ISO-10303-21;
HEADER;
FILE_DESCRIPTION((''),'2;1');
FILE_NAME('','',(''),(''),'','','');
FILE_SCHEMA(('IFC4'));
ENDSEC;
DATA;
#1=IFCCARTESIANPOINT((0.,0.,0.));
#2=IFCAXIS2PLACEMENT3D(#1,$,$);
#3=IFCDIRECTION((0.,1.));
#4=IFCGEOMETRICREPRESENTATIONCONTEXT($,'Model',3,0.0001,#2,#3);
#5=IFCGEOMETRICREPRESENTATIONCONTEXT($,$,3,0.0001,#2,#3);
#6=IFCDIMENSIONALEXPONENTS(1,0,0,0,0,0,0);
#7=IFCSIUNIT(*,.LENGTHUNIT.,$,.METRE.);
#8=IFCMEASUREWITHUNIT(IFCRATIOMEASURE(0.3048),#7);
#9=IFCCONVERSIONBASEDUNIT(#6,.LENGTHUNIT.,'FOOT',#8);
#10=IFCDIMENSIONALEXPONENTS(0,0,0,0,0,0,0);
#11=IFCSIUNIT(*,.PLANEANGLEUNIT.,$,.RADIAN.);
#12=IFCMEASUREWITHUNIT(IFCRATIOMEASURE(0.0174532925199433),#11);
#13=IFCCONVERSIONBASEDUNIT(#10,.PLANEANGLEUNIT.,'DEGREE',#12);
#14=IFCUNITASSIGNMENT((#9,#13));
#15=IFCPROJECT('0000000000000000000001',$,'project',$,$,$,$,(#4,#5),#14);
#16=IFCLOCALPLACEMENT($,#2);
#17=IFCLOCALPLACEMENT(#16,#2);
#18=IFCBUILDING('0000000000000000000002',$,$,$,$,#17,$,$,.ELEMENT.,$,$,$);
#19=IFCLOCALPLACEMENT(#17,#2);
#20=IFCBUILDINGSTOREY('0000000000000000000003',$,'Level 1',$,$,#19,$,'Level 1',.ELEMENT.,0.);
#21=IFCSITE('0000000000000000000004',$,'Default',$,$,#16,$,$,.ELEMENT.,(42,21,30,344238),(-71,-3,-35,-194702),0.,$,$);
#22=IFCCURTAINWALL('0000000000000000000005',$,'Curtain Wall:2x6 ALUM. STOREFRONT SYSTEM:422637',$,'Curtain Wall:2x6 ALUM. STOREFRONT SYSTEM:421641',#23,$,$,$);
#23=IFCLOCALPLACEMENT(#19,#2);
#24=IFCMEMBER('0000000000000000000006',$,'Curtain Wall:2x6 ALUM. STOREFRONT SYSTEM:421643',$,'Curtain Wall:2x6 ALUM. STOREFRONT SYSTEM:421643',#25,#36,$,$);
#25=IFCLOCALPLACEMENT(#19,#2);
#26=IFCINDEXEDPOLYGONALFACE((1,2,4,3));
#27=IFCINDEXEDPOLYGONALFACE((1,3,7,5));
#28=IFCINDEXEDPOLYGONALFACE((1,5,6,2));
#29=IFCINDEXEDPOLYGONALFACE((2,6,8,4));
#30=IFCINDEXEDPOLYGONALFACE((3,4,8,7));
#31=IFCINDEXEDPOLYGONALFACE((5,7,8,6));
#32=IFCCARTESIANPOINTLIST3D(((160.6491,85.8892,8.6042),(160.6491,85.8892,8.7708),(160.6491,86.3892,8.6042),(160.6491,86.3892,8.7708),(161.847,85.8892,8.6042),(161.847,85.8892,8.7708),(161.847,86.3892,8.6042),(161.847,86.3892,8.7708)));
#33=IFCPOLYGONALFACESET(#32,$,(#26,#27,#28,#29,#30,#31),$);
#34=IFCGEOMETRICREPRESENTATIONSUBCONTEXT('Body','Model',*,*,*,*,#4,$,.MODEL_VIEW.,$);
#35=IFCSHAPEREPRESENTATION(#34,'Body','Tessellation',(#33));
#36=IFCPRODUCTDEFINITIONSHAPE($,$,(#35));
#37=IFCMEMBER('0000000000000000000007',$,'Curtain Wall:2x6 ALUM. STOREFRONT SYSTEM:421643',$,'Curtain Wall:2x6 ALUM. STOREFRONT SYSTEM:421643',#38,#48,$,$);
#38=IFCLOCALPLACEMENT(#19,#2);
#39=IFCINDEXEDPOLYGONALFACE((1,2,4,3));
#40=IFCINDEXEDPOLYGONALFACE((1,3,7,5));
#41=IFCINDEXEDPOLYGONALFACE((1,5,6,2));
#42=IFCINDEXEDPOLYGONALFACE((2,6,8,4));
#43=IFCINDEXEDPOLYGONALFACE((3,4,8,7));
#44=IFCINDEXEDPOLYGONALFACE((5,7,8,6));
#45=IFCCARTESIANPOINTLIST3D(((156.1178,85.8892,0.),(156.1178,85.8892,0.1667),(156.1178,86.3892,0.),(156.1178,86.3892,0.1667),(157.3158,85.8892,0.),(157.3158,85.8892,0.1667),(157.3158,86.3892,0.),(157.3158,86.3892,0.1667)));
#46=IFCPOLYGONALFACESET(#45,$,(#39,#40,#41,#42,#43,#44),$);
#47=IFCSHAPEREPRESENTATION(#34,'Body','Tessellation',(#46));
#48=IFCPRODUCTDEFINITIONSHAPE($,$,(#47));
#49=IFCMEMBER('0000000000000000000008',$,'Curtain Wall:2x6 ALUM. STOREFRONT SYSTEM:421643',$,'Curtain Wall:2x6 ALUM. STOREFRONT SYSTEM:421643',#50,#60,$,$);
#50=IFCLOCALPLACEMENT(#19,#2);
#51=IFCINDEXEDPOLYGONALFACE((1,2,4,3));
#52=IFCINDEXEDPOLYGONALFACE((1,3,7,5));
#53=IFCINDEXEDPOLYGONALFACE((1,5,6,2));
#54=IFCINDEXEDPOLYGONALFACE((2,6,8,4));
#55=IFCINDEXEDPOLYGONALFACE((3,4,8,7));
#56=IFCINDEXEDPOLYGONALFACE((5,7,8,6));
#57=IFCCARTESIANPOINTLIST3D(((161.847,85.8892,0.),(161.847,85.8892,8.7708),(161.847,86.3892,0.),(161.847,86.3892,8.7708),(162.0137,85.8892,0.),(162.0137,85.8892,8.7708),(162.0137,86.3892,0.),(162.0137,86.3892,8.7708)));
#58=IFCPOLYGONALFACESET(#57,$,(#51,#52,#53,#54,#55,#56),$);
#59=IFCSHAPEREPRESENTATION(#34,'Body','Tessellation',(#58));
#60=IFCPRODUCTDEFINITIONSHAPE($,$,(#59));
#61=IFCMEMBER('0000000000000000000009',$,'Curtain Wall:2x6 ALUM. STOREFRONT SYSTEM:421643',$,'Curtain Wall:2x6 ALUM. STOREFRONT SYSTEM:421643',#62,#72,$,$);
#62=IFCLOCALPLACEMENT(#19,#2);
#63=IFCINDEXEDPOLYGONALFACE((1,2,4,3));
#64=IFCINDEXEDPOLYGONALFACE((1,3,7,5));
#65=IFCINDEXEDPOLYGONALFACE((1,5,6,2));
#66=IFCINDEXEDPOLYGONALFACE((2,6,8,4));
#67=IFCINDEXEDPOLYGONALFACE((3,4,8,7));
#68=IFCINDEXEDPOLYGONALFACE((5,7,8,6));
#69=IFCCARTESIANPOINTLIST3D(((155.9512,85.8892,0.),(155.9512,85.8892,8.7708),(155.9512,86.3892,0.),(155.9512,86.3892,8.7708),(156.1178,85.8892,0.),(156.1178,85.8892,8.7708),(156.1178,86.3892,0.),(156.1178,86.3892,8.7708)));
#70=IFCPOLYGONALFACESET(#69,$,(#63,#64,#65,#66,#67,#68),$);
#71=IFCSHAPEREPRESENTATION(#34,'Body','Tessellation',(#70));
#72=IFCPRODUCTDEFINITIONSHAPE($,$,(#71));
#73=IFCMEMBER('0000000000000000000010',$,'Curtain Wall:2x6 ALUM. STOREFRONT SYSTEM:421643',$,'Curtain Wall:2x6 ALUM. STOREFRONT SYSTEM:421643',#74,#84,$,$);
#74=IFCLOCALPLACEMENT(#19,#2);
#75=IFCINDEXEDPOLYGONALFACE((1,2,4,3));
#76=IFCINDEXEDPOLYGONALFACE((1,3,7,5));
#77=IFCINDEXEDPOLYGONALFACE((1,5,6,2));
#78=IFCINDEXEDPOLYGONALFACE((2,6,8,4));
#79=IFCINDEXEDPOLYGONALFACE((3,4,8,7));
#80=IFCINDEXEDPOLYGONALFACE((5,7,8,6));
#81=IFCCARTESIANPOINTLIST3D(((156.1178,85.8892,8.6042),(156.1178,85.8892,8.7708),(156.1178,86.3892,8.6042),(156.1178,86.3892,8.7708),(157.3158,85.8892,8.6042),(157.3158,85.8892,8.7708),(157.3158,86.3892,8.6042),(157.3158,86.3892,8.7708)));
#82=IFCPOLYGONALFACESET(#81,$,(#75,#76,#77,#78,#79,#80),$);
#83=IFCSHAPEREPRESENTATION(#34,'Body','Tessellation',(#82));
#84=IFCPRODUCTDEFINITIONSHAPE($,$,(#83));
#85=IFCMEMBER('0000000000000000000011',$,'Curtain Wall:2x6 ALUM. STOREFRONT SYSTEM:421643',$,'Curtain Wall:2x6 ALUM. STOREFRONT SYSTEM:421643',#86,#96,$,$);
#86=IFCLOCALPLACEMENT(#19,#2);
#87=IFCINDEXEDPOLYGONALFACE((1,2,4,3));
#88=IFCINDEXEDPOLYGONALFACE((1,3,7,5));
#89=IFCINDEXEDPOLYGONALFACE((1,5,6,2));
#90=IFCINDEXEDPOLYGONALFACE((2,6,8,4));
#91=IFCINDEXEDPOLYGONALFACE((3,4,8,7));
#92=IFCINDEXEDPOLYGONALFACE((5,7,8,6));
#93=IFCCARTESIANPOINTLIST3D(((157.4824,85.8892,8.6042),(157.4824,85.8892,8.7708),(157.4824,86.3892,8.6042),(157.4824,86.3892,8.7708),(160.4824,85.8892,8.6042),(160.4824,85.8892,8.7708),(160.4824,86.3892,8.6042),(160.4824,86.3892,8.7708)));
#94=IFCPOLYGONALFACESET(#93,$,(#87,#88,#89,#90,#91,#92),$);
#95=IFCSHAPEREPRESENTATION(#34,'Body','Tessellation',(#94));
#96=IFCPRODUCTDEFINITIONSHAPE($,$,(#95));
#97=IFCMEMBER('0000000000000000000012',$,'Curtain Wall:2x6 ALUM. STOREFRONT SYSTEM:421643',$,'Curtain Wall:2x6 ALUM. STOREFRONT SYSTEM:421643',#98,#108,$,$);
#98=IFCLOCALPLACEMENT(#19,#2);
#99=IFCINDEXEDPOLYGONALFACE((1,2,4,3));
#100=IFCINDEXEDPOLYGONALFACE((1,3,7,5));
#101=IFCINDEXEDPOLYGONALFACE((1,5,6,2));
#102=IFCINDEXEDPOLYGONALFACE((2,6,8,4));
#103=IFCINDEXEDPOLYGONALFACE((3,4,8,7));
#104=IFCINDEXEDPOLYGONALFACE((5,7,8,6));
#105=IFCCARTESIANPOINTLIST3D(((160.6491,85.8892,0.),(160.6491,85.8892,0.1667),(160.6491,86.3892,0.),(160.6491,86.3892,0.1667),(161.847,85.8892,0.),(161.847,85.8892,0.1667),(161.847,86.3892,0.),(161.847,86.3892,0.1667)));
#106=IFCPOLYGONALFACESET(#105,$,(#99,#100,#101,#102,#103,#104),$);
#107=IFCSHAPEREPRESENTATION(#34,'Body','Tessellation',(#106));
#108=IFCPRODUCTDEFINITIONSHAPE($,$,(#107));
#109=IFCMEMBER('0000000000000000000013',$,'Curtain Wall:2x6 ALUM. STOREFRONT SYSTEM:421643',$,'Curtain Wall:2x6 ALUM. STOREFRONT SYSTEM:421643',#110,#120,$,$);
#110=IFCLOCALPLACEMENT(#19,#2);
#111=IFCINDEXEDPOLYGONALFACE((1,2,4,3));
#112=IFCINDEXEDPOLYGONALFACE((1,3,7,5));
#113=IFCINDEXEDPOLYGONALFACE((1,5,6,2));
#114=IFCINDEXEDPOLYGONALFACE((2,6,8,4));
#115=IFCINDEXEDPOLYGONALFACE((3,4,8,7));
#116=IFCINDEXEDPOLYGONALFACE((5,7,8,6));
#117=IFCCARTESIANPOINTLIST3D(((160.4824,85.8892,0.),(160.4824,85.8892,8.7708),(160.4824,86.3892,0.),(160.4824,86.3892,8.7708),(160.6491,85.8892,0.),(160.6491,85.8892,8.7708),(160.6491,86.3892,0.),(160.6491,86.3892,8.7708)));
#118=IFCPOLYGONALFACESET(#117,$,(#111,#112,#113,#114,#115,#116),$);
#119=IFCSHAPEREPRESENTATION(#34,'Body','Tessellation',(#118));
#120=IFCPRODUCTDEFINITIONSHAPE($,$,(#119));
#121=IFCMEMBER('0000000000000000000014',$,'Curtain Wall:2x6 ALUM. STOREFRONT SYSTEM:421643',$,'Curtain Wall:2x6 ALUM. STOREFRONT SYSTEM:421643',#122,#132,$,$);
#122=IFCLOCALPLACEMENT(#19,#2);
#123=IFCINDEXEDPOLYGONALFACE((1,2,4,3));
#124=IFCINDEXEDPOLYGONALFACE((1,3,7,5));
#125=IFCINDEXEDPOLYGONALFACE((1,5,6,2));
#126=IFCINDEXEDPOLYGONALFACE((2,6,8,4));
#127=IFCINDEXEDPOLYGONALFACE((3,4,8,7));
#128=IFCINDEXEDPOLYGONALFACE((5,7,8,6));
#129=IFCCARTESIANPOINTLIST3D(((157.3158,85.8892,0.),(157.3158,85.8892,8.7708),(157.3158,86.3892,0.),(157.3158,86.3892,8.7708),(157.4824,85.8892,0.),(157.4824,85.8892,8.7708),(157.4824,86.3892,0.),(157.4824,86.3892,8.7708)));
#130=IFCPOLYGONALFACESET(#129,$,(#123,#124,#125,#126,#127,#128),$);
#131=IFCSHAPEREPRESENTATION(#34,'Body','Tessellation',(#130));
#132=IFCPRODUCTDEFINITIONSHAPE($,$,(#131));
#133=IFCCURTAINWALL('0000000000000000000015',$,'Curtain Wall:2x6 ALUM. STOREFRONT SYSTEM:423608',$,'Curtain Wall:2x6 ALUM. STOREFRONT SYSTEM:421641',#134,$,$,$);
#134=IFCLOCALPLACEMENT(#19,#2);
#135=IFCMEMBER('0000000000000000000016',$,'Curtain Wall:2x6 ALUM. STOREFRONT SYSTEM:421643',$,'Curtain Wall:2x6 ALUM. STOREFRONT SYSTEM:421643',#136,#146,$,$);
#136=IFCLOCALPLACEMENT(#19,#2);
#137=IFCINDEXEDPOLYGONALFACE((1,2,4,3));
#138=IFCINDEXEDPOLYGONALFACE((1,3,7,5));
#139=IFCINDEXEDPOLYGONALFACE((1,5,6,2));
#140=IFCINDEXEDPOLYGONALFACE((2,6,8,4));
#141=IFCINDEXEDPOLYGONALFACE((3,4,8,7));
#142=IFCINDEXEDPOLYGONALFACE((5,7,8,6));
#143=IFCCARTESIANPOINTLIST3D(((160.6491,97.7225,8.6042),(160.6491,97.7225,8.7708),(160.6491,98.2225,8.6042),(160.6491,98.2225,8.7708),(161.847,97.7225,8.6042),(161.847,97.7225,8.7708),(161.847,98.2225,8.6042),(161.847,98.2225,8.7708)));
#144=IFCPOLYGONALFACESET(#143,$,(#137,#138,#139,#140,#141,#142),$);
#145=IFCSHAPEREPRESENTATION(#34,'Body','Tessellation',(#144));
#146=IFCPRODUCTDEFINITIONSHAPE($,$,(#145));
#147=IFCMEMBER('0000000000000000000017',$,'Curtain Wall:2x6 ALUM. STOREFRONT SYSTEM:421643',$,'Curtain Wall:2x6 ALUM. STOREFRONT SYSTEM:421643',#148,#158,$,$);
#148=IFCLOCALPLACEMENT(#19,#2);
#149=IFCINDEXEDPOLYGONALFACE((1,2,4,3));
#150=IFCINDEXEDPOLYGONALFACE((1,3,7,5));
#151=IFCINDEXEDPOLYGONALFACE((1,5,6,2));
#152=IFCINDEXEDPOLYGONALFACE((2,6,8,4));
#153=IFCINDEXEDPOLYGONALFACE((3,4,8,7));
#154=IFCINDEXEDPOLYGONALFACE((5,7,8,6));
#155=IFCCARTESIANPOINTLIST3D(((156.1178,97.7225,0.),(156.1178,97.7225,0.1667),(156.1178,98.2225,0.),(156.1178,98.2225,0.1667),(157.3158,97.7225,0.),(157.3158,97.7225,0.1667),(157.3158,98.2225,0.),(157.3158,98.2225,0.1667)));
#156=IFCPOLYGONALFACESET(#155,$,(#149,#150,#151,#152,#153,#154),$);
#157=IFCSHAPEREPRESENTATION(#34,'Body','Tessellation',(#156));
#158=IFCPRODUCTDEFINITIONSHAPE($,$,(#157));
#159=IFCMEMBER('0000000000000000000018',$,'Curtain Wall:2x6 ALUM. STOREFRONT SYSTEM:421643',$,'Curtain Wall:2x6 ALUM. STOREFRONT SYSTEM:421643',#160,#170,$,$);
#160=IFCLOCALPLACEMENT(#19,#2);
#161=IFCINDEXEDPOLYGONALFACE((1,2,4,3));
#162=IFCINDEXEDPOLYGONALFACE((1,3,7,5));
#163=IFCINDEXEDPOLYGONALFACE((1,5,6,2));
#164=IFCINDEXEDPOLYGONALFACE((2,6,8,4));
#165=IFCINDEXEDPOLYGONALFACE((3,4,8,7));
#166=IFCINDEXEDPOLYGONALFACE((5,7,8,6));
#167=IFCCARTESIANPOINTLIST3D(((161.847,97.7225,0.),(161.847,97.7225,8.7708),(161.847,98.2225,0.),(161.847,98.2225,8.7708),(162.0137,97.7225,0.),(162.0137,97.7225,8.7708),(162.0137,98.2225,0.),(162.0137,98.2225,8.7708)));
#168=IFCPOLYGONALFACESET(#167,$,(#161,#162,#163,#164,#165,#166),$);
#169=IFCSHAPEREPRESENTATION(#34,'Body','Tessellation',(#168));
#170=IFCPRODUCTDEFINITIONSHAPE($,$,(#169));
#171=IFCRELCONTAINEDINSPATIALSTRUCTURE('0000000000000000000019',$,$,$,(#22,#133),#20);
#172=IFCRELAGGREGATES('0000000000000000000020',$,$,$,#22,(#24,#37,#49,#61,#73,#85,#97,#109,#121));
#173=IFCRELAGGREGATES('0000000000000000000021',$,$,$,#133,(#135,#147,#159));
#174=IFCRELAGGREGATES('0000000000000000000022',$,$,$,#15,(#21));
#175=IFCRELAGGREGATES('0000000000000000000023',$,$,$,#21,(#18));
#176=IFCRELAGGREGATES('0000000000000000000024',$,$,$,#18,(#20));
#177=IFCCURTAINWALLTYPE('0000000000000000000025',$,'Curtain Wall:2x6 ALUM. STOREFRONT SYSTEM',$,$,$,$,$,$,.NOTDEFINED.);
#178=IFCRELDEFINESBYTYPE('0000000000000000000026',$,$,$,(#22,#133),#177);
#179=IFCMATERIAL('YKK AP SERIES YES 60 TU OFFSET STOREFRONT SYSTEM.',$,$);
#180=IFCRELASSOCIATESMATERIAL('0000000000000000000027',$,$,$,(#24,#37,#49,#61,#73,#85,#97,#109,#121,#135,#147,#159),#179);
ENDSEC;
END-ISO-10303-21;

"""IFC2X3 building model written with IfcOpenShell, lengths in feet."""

from ifc_helpers import new_model, entity, si_unit, converted_unit, direction, frame, frame_2d, origin, origin_2d_with_axis, place, context, subcontext, project, spatial, rectangle, extrude, material, type_object, element, aggregate, save


model = new_model("IFC2X3")

# Units and contexts
model_context = context("Model", 3, precision=0.0001, world=origin(), true_north=direction((0.0, 1.0)))
context_of_model = context(None, 3, precision=0.0001, world=origin(), true_north=direction((0.0, 1.0)))
body_context = subcontext(model_context, "Body", "Model", "MODEL_VIEW")
ifc_project = project(units=[converted_unit("LENGTHUNIT", "FOOT", entity("IfcRatioMeasure", 0.3048), si_unit("LENGTHUNIT", "METRE"), dimensions=[1, 0, 0, 0, 0, 0, 0]), converted_unit("PLANEANGLEUNIT", "DEGREE", entity("IfcRatioMeasure", 0.0174532925199433), si_unit("PLANEANGLEUNIT", "RADIAN"), dimensions=[0, 0, 0, 0, 0, 0, 0])], contexts=[model_context, context_of_model])

# Site, building, storey
site_placement = place(None, origin())
site = spatial("IfcSite", under=ifc_project, at=site_placement, Name="Default", CompositionType="ELEMENT", RefLatitude=(42, 21, 30, 344238), RefLongitude=(-71, -3, -35, -194702), RefElevation=0.0)
building_placement = place(site_placement, origin())
building = spatial("IfcBuilding", under=site, at=building_placement, CompositionType="ELEMENT")
storey_placement = place(building_placement, origin())
storey = spatial("IfcBuildingStorey", under=building, at=storey_placement, Name="Level 1", LongName="Level 1", CompositionType="ELEMENT", Elevation=0.0)

# Curtain walls, members
curtain_wall_type = type_object("IfcCurtainWallType", Name="Curtain Wall:2x6 ALUM. STOREFRONT SYSTEM", PredefinedType="NOTDEFINED")
curtain_wall_1_placement = place(storey_placement, origin())
curtain_wall_1 = element("IfcCurtainWall", 1, at=curtain_wall_1_placement, inside=storey, type_object=curtain_wall_type, Name="Curtain Wall:2x6 ALUM. STOREFRONT SYSTEM:422637", ObjectType="Curtain Wall:2x6 ALUM. STOREFRONT SYSTEM:421641")
ifc_material_1 = material(Name="YKK AP SERIES YES 60 TU OFFSET STOREFRONT SYSTEM.")
member_1_placement = place(curtain_wall_1_placement, origin())
member_1 = element("IfcMember", 2, at=member_1_placement, material=ifc_material_1, Name="Curtain Wall:2x6 ALUM. STOREFRONT SYSTEM:421643", ObjectType="Curtain Wall:2x6 ALUM. STOREFRONT SYSTEM:421643", context=body_context, shape_type="SweptSolid", body=[
    extrude(rectangle(XDim=0.1667, YDim=0.5, at=frame_2d((0.0, 0.0), x_axis=(1.0, 0.0))), frame((161.847, 86.1392, 8.6875), z_axis=(-1.0, 0.0, 0.0), x_axis=(0.0, 0.0, -1.0)), (0.0, 0.0, 1.0), 1.1979),
])
member_2_placement = place(curtain_wall_1_placement, origin())
member_2 = element("IfcMember", 3, at=member_2_placement, material=ifc_material_1, Name="Curtain Wall:2x6 ALUM. STOREFRONT SYSTEM:421643", ObjectType="Curtain Wall:2x6 ALUM. STOREFRONT SYSTEM:421643", context=body_context, shape_type="SweptSolid", body=[
    extrude(rectangle(XDim=0.1667, YDim=0.5, at=origin_2d_with_axis()), frame((156.1178, 86.1392, 0.0833), z_axis=(1.0, 0.0, 0.0), x_axis=(0.0, 0.0, -1.0)), (0.0, 0.0, 1.0), 1.1979),
])
member_3_placement = place(curtain_wall_1_placement, origin())
member_3 = element("IfcMember", 4, at=member_3_placement, material=ifc_material_1, Name="Curtain Wall:2x6 ALUM. STOREFRONT SYSTEM:421643", ObjectType="Curtain Wall:2x6 ALUM. STOREFRONT SYSTEM:421643", context=body_context, shape_type="SweptSolid", body=[
    extrude(rectangle(XDim=0.1667, YDim=0.5, at=frame_2d((0.0, 0.0), x_axis=(1.0, 0.0))), frame((161.9303, 86.1392, 0.0), z_axis=(0.0, 0.0, 1.0), x_axis=(-1.0, 0.0, 0.0)), (0.0, 0.0, 1.0), 8.7708),
])
member_4_placement = place(curtain_wall_1_placement, origin())
member_4 = element("IfcMember", 5, at=member_4_placement, material=ifc_material_1, Name="Curtain Wall:2x6 ALUM. STOREFRONT SYSTEM:421643", ObjectType="Curtain Wall:2x6 ALUM. STOREFRONT SYSTEM:421643", context=body_context, shape_type="SweptSolid", body=[
    extrude(rectangle(XDim=0.1667, YDim=0.5, at=frame_2d((0.0, 0.0), x_axis=(1.0, 0.0))), frame((156.0345, 86.1392, 8.7708), z_axis=(0.0, 0.0, -1.0), x_axis=(-1.0, 0.0, 0.0)), (0.0, 0.0, 1.0), 8.7708),
])
member_5_placement = place(curtain_wall_1_placement, origin())
member_5 = element("IfcMember", 6, at=member_5_placement, material=ifc_material_1, Name="Curtain Wall:2x6 ALUM. STOREFRONT SYSTEM:421643", ObjectType="Curtain Wall:2x6 ALUM. STOREFRONT SYSTEM:421643", context=body_context, shape_type="SweptSolid", body=[
    extrude(rectangle(XDim=0.1667, YDim=0.5, at=frame_2d((0.0, 0.0), x_axis=(1.0, 0.0))), frame((157.3158, 86.1392, 8.6875), z_axis=(-1.0, 0.0, 0.0), x_axis=(0.0, 0.0, -1.0)), (0.0, 0.0, 1.0), 1.1979),
])
member_6_placement = place(curtain_wall_1_placement, origin())
member_6 = element("IfcMember", 7, at=member_6_placement, material=ifc_material_1, Name="Curtain Wall:2x6 ALUM. STOREFRONT SYSTEM:421643", ObjectType="Curtain Wall:2x6 ALUM. STOREFRONT SYSTEM:421643", context=body_context, shape_type="SweptSolid", body=[
    extrude(rectangle(XDim=0.1667, YDim=0.5, at=frame_2d((0.0, 0.0), x_axis=(1.0, 0.0))), frame((160.4824, 86.1392, 8.6875), z_axis=(-1.0, 0.0, 0.0), x_axis=(0.0, 0.0, -1.0)), (0.0, 0.0, 1.0), 3.0),
])
member_7_placement = place(curtain_wall_1_placement, origin())
member_7 = element("IfcMember", 8, at=member_7_placement, material=ifc_material_1, Name="Curtain Wall:2x6 ALUM. STOREFRONT SYSTEM:421643", ObjectType="Curtain Wall:2x6 ALUM. STOREFRONT SYSTEM:421643", context=body_context, shape_type="SweptSolid", body=[
    extrude(rectangle(XDim=0.1667, YDim=0.5, at=origin_2d_with_axis()), frame((160.6491, 86.1392, 0.0833), z_axis=(1.0, 0.0, 0.0), x_axis=(0.0, 0.0, -1.0)), (0.0, 0.0, 1.0), 1.1979),
])
member_8_placement = place(curtain_wall_1_placement, origin())
member_8 = element("IfcMember", 9, at=member_8_placement, material=ifc_material_1, Name="Curtain Wall:2x6 ALUM. STOREFRONT SYSTEM:421643", ObjectType="Curtain Wall:2x6 ALUM. STOREFRONT SYSTEM:421643", context=body_context, shape_type="SweptSolid", body=[
    extrude(rectangle(XDim=0.1667, YDim=0.5, at=origin_2d_with_axis()), frame((160.5658, 86.1392, 0.0), z_axis=(0.0, 0.0, 1.0), x_axis=(-1.0, 0.0, 0.0)), (0.0, 0.0, 1.0), 8.7708),
])
member_9_placement = place(curtain_wall_1_placement, origin())
member_9 = element("IfcMember", 10, at=member_9_placement, material=ifc_material_1, Name="Curtain Wall:2x6 ALUM. STOREFRONT SYSTEM:421643", ObjectType="Curtain Wall:2x6 ALUM. STOREFRONT SYSTEM:421643", context=body_context, shape_type="SweptSolid", body=[
    extrude(rectangle(XDim=0.1667, YDim=0.5, at=frame_2d((0.0, 0.0), x_axis=(1.0, 0.0))), frame((157.3991, 86.1392, 0.0), z_axis=(0.0, 0.0, 1.0), x_axis=(-1.0, 0.0, 0.0)), (0.0, 0.0, 1.0), 8.7708),
])
aggregate(curtain_wall_1, [member_1, member_2, member_3, member_4, member_5, member_6, member_7, member_8, member_9])
curtain_wall_2_placement = place(storey_placement, origin())
curtain_wall_2 = element("IfcCurtainWall", 11, at=curtain_wall_2_placement, inside=storey, type_object=curtain_wall_type, Name="Curtain Wall:2x6 ALUM. STOREFRONT SYSTEM:423608", ObjectType="Curtain Wall:2x6 ALUM. STOREFRONT SYSTEM:421641")
member_10_placement = place(curtain_wall_2_placement, origin())
member_10 = element("IfcMember", 12, at=member_10_placement, material=ifc_material_1, Name="Curtain Wall:2x6 ALUM. STOREFRONT SYSTEM:421643", ObjectType="Curtain Wall:2x6 ALUM. STOREFRONT SYSTEM:421643", context=body_context, shape_type="SweptSolid", body=[
    extrude(rectangle(XDim=0.1667, YDim=0.5, at=frame_2d((0.0, 0.0), x_axis=(1.0, 0.0))), frame((161.847, 97.9725, 8.6875), z_axis=(-1.0, 0.0, 0.0), x_axis=(0.0, 0.0, -1.0)), (0.0, 0.0, 1.0), 1.1979),
])
member_11_placement = place(curtain_wall_2_placement, origin())
member_11 = element("IfcMember", 13, at=member_11_placement, material=ifc_material_1, Name="Curtain Wall:2x6 ALUM. STOREFRONT SYSTEM:421643", ObjectType="Curtain Wall:2x6 ALUM. STOREFRONT SYSTEM:421643", context=body_context, shape_type="SweptSolid", body=[
    extrude(rectangle(XDim=0.1667, YDim=0.5, at=origin_2d_with_axis()), frame((156.1178, 97.9725, 0.0833), z_axis=(1.0, 0.0, 0.0), x_axis=(0.0, 0.0, -1.0)), (0.0, 0.0, 1.0), 1.1979),
])
member_12_placement = place(curtain_wall_2_placement, origin())
member_12 = element("IfcMember", 14, at=member_12_placement, material=ifc_material_1, Name="Curtain Wall:2x6 ALUM. STOREFRONT SYSTEM:421643", ObjectType="Curtain Wall:2x6 ALUM. STOREFRONT SYSTEM:421643", context=body_context, shape_type="SweptSolid", body=[
    extrude(rectangle(XDim=0.1667, YDim=0.5, at=frame_2d((0.0, 0.0), x_axis=(1.0, 0.0))), frame((161.9303, 97.9725, 0.0), z_axis=(0.0, 0.0, 1.0), x_axis=(-1.0, 0.0, 0.0)), (0.0, 0.0, 1.0), 8.7708),
])
aggregate(curtain_wall_2, [member_10, member_11, member_12])

save(model, "model.ifc")
